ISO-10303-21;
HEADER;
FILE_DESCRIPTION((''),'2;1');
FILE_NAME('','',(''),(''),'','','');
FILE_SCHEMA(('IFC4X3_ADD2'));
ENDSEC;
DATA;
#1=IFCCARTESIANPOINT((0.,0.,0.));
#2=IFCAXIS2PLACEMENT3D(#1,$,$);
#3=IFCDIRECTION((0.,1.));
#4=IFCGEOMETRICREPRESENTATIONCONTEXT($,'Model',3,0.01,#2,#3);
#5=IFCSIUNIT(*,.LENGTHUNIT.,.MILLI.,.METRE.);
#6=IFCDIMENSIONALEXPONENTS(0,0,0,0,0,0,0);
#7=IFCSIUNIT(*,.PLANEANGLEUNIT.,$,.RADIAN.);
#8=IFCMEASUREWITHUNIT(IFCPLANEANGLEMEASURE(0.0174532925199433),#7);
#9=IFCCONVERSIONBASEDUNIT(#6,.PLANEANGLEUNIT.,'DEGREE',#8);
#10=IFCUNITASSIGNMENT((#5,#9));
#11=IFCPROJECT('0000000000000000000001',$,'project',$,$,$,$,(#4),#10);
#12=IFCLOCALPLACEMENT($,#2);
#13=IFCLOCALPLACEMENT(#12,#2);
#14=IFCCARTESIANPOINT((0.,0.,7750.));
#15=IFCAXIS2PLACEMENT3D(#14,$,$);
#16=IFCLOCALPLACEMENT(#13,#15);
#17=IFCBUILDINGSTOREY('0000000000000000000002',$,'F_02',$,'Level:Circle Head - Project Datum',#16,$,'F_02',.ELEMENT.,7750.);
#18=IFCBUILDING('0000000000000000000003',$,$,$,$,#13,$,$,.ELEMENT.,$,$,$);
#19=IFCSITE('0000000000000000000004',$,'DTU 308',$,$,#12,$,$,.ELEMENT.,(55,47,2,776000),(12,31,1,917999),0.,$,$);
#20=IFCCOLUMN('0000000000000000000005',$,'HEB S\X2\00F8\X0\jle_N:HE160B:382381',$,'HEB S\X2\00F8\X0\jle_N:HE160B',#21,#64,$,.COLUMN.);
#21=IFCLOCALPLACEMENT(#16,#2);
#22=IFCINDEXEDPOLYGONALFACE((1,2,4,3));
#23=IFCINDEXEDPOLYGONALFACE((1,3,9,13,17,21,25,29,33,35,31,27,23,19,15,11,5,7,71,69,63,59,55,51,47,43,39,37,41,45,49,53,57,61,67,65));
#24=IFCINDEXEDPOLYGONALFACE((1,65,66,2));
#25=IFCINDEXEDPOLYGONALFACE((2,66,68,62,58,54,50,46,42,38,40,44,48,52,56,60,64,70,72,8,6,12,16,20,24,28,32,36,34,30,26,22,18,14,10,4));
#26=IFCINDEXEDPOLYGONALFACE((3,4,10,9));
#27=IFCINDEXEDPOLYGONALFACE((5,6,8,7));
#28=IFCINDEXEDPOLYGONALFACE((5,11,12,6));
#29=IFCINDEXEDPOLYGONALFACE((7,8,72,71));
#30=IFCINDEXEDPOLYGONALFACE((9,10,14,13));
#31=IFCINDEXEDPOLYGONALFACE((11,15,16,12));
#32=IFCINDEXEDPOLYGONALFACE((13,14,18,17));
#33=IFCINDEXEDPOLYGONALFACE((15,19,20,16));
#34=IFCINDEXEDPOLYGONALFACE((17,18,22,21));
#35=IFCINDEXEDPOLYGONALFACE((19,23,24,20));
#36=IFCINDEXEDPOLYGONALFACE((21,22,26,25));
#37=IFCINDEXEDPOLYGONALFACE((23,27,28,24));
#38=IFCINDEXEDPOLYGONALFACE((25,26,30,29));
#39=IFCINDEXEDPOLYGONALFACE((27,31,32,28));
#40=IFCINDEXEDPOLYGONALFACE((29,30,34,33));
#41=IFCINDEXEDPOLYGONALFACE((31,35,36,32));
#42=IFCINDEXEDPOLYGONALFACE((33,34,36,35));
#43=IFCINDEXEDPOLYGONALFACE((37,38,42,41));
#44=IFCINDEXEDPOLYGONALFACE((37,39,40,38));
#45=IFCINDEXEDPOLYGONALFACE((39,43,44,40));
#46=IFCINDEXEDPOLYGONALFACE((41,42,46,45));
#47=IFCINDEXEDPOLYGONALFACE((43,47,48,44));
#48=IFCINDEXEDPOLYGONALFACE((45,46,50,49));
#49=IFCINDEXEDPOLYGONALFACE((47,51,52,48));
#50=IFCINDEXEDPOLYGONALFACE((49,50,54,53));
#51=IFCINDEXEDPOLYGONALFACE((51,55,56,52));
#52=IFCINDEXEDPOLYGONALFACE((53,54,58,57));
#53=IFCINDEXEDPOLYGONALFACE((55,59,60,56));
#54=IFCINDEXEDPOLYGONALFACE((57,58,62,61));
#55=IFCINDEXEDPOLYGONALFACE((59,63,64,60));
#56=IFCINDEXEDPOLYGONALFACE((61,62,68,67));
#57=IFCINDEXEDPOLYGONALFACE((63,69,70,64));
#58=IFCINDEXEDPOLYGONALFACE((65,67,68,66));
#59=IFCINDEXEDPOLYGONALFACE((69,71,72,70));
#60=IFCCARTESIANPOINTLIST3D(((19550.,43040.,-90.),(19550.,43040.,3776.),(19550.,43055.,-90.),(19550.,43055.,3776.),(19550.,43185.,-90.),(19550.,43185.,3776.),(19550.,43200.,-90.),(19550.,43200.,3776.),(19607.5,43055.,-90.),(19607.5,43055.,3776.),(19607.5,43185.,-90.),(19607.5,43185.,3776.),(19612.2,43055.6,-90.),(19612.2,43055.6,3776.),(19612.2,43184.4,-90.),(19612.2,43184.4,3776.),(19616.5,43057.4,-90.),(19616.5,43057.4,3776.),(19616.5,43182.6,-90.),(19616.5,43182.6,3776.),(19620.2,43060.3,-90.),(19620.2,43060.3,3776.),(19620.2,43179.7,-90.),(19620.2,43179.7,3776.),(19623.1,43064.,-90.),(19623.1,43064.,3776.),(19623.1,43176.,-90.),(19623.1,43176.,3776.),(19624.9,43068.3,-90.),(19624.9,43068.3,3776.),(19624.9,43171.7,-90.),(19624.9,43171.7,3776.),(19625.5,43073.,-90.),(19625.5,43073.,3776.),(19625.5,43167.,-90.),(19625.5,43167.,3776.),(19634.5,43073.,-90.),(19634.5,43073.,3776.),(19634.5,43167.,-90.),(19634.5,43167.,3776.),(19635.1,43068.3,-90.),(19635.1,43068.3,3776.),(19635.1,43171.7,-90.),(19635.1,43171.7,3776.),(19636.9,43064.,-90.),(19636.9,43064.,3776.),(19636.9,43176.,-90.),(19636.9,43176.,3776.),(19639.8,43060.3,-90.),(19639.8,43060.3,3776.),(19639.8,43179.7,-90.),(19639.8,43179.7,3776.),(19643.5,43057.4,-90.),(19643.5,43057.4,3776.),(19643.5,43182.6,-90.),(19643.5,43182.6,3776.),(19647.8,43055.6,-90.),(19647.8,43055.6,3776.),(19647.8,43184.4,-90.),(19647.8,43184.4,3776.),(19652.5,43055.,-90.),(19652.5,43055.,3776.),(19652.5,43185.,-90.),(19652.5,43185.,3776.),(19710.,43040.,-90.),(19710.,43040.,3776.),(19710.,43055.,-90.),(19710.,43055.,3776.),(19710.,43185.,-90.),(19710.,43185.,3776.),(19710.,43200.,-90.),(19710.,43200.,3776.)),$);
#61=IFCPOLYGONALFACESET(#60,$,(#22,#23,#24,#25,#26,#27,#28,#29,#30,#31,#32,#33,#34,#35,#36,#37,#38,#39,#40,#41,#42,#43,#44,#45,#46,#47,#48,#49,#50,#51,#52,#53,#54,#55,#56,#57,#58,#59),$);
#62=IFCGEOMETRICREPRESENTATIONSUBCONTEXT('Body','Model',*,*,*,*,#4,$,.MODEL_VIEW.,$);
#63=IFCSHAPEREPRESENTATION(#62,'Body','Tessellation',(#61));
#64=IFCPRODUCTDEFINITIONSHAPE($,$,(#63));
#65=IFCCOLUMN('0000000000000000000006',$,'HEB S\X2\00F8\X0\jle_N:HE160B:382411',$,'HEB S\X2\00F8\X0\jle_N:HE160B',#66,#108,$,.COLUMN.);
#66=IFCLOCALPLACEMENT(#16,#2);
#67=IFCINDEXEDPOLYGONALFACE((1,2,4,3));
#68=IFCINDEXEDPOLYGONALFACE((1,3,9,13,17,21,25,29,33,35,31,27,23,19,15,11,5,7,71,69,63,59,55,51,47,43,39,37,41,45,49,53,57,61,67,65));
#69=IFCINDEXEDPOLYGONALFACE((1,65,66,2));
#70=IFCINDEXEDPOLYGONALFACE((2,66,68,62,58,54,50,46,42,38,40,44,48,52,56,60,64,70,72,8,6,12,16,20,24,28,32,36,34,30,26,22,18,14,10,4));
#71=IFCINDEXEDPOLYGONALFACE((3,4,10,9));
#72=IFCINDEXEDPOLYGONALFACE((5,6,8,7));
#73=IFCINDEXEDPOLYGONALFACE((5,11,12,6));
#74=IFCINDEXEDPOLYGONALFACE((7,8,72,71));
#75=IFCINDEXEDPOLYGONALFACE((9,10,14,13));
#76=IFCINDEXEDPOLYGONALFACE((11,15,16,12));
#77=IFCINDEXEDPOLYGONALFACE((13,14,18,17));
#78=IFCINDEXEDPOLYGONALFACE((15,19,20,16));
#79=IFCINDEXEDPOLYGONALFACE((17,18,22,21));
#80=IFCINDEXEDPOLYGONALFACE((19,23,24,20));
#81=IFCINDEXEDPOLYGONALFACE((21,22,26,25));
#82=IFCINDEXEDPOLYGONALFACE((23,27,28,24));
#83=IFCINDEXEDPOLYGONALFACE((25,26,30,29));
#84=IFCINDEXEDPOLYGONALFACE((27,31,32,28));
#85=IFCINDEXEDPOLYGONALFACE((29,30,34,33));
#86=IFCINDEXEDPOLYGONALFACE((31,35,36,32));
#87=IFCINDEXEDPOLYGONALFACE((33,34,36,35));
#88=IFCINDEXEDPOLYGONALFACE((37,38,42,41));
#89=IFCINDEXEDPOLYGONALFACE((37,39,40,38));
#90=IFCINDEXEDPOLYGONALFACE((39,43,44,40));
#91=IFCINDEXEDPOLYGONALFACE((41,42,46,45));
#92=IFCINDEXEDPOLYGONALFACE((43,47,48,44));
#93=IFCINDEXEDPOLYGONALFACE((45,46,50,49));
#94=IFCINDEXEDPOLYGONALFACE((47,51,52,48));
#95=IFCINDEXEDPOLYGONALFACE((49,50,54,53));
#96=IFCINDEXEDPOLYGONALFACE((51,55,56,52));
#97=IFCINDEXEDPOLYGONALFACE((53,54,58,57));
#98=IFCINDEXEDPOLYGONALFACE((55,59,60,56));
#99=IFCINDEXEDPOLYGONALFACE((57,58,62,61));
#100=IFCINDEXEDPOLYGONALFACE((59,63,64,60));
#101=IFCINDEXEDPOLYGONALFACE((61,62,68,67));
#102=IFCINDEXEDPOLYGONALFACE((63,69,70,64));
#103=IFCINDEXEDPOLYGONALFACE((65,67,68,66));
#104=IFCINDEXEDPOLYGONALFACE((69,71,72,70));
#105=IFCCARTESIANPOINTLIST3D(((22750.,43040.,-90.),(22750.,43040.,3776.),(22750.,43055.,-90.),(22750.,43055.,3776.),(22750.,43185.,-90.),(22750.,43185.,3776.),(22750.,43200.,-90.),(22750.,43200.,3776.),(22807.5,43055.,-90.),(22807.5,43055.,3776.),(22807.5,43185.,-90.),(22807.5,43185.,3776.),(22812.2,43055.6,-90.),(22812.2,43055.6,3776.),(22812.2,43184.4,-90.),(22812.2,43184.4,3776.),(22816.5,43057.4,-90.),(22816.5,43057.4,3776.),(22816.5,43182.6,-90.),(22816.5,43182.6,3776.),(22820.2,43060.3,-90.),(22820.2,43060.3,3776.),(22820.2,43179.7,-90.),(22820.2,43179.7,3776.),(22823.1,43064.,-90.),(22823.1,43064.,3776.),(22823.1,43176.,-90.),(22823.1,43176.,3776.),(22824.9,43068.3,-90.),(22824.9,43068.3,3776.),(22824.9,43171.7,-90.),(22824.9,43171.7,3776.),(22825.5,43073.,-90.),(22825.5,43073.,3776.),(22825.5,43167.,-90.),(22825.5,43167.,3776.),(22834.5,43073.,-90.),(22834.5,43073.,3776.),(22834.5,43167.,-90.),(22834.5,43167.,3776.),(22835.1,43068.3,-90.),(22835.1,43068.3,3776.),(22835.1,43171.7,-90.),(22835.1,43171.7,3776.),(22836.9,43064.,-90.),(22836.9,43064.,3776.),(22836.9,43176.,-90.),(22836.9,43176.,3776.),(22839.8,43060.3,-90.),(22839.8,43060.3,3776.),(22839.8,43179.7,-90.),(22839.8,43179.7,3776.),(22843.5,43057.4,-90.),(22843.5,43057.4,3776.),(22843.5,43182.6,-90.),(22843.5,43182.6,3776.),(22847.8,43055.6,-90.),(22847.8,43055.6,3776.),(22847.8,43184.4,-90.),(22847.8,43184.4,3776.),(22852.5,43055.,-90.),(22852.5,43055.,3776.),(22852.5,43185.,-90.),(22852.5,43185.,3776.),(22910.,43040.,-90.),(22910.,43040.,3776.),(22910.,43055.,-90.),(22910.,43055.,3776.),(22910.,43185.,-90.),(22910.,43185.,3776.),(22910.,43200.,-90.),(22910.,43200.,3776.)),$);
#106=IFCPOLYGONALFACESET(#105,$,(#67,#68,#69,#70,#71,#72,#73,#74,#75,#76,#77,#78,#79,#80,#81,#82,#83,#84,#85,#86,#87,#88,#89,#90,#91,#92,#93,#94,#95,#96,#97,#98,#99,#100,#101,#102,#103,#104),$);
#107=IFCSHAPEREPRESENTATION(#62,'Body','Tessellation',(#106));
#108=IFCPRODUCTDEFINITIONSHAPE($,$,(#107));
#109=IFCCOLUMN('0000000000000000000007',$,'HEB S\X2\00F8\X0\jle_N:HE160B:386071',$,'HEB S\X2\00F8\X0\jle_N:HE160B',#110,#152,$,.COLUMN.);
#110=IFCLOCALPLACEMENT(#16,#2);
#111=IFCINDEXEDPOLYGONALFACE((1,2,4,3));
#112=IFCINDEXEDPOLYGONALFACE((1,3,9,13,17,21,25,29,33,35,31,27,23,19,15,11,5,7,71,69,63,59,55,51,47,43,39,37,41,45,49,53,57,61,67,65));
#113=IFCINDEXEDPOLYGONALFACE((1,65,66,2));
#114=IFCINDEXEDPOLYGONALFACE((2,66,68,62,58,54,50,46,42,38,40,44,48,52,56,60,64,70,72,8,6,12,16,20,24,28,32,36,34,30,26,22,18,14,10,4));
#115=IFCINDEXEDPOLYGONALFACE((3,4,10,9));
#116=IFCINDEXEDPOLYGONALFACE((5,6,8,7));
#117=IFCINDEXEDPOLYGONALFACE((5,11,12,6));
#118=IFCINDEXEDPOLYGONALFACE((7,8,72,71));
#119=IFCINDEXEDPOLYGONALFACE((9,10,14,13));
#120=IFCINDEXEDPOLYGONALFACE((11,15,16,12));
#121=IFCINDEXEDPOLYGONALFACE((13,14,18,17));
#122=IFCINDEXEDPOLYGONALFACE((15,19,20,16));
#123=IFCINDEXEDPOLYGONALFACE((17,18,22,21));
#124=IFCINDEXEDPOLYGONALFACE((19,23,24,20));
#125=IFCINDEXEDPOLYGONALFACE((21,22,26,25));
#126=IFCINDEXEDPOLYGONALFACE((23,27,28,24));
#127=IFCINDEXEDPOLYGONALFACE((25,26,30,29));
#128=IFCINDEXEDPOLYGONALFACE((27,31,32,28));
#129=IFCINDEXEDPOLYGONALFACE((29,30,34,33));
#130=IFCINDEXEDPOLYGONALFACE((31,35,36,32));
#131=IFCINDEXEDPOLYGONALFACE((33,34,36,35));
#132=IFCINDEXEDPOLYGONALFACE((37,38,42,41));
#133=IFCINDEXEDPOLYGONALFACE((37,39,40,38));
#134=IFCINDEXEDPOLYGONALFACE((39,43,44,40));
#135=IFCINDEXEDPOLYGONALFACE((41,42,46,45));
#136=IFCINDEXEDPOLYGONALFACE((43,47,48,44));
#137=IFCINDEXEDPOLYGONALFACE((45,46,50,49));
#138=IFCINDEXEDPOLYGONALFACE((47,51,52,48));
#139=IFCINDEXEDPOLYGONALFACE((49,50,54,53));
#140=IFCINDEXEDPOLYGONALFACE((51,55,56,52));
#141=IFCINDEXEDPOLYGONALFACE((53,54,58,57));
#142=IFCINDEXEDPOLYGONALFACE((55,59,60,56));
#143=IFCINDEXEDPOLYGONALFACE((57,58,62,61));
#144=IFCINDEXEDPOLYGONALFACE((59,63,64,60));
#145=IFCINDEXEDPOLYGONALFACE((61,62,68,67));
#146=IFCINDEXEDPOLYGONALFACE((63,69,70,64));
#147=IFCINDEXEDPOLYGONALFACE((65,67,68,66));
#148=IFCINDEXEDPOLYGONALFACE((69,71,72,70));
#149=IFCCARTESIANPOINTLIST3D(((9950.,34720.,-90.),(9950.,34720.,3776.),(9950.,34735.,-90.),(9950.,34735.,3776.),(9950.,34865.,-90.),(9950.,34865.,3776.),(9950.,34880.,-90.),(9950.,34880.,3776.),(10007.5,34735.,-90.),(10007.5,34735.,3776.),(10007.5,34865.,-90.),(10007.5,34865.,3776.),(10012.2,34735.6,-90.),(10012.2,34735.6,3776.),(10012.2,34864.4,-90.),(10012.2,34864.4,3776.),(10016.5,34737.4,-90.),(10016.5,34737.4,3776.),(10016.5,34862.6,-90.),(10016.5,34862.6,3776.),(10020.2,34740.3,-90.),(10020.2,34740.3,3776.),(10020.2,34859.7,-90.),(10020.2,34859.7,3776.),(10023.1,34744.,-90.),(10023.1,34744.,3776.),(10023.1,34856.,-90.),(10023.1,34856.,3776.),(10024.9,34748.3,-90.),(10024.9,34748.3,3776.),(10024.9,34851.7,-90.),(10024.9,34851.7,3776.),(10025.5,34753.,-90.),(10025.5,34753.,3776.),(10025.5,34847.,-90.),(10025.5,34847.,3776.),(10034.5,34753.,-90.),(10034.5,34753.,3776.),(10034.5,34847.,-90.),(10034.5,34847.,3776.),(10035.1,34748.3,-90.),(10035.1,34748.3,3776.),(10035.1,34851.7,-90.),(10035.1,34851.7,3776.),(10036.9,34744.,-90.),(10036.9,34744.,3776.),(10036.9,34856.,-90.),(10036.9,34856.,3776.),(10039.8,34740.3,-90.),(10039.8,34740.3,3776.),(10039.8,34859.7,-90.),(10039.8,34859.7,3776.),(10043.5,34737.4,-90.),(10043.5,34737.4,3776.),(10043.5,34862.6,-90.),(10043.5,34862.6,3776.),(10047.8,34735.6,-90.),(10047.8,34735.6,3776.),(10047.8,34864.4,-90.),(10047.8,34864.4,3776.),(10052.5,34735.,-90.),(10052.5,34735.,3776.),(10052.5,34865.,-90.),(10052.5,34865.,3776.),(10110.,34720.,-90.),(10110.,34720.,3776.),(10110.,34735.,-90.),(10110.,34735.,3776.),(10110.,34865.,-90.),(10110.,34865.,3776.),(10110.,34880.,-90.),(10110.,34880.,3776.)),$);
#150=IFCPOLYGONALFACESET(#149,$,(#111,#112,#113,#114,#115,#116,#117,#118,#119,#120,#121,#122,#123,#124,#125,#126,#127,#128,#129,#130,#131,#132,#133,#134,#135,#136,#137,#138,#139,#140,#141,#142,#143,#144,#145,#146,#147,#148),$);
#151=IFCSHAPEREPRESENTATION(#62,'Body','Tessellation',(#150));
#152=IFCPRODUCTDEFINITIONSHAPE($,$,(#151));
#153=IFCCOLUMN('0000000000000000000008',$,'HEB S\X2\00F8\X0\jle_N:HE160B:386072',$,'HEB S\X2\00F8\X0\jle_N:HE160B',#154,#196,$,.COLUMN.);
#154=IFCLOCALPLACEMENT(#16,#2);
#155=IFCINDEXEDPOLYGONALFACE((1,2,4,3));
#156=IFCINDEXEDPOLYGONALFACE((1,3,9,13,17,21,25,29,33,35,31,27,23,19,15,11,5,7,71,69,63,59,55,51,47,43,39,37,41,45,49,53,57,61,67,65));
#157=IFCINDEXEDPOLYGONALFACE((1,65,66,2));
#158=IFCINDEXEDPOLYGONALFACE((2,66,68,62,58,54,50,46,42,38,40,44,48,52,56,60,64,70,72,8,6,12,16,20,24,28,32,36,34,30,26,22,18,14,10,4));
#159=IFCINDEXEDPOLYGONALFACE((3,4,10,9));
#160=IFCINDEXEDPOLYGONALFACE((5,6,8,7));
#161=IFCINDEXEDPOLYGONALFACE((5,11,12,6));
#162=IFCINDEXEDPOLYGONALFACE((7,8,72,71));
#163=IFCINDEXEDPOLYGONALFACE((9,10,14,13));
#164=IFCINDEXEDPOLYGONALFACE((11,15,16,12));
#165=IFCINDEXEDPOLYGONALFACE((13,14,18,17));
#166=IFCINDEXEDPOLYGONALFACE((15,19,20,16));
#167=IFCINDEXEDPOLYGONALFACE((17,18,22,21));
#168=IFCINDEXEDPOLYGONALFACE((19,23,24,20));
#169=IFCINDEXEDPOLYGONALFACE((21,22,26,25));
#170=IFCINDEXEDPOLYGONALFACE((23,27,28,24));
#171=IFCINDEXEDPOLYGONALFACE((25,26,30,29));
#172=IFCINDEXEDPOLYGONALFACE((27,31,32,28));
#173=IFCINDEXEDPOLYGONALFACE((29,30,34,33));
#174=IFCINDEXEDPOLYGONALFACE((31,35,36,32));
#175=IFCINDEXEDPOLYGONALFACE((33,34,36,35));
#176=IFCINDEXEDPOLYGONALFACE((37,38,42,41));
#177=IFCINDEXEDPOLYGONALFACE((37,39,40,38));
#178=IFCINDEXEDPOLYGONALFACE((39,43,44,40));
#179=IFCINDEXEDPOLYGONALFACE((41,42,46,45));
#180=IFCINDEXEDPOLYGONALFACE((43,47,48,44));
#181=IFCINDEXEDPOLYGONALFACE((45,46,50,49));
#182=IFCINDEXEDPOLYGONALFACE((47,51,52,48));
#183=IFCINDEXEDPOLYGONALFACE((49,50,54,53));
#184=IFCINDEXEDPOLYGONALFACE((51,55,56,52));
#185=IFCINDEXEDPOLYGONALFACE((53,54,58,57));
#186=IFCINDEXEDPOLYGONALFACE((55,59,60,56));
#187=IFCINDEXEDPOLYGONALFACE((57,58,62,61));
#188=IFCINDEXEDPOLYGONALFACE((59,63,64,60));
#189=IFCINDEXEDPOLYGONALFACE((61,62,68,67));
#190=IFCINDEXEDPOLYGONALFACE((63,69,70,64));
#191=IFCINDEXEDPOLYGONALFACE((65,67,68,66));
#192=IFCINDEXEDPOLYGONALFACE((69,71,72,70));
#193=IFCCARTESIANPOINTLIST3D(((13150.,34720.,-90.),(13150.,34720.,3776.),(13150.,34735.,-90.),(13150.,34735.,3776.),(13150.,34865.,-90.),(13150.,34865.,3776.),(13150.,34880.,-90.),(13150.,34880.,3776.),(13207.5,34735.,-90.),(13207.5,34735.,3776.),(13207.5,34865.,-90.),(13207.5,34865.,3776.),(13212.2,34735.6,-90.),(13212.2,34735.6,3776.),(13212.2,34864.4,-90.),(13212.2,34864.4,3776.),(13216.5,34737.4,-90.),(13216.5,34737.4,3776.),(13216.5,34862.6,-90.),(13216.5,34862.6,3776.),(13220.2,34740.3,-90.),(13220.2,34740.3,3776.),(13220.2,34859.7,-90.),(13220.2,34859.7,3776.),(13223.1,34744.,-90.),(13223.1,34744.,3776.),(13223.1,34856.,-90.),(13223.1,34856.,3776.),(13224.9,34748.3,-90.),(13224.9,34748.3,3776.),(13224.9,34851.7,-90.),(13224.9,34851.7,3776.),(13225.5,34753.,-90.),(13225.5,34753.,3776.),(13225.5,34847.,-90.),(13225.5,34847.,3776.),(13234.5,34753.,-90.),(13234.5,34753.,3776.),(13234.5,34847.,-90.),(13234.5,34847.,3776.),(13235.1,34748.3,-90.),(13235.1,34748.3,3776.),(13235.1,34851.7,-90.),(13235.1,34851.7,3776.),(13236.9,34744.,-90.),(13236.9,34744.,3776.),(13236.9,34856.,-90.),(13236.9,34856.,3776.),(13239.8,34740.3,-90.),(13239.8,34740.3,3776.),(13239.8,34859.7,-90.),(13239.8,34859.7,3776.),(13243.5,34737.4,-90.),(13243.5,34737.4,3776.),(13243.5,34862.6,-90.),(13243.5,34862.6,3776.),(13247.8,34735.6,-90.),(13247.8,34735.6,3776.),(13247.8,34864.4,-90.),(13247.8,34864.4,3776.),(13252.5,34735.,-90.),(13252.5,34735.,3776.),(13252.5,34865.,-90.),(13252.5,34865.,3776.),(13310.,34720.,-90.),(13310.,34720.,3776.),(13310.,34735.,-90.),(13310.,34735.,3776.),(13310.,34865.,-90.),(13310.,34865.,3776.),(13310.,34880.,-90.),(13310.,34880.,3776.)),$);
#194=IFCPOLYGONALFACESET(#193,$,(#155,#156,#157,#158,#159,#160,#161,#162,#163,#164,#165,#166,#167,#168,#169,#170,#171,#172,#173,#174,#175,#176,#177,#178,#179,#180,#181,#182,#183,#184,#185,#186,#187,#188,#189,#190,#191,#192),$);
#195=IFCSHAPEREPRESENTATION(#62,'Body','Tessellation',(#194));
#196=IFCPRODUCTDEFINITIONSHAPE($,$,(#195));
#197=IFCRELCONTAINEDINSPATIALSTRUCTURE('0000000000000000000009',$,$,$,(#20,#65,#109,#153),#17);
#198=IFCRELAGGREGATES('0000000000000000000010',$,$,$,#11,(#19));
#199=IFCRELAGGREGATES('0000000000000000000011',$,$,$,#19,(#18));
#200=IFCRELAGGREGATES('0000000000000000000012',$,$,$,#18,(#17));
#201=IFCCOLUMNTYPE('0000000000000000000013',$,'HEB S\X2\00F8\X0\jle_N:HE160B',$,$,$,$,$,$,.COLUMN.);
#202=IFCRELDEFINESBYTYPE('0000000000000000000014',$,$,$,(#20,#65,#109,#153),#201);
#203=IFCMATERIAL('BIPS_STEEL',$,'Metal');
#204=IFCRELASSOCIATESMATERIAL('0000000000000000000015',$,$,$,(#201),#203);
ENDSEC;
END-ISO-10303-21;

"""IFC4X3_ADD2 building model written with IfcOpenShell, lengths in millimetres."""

from ifc_helpers import new_model, entity, si_unit, converted_unit, direction, frame, frame_2d, origin, place, context, subcontext, project, spatial, i_section, extrude, source, transform, mapped, material, material_profile, profile_set, type_object, element, save


model = new_model("IFC4X3_ADD2")

# Units and contexts
model_context = context("Model", 3, precision=0.01, world=origin(), true_north=direction((0.0, 1.0)))
body_context = subcontext(model_context, "Body", "Model", "MODEL_VIEW")
ifc_project = project(units=[si_unit("LENGTHUNIT", "METRE", prefix="MILLI"), converted_unit("PLANEANGLEUNIT", "DEGREE", entity("IfcPlaneAngleMeasure", 0.0174532925199433), si_unit("PLANEANGLEUNIT", "RADIAN"), dimensions=[0, 0, 0, 0, 0, 0, 0])], contexts=[model_context])

# Site, building, storey
site_placement = place(None, origin())
site = spatial("IfcSite", under=ifc_project, at=site_placement, Name="DTU 308", CompositionType="ELEMENT", RefLatitude=(55, 47, 2, 776000), RefLongitude=(12, 31, 1, 917999), RefElevation=0.0)
building_placement = place(site_placement, origin())
building = spatial("IfcBuilding", under=site, at=building_placement, CompositionType="ELEMENT")
storey_placement = place(building_placement, frame((0.0, 0.0, 7750.0)))
storey = spatial("IfcBuildingStorey", under=building, at=storey_placement, Name="F_02", ObjectType="Level:Circle Head - Project Datum", LongName="F_02", CompositionType="ELEMENT", Elevation=7750.0)

# Columns
ifc_material = material(Name="BIPS_STEEL", Category="Metal")
ifc_material_profile_1 = material_profile(ifc_material, i_section(OverallWidth=160.0, OverallDepth=160.0, WebThickness=9.0, FlangeThickness=15.0, FilletRadius=18.0, at=frame_2d((0.0, 0.0), x_axis=(1.0, 0.0))), Name="HE160B")
ifc_profile_set_1 = profile_set([ifc_material_profile_1], Name="HE160B")
column_type_1 = type_object("IfcColumnType", Name="HEB Søjle_N:HE160B", PredefinedType="COLUMN", material=ifc_profile_set_1)
shared_shape_1 = source(origin(), body_context, "Body", "SweptSolid", [
    extrude(i_section(OverallWidth=160.0, OverallDepth=160.0, WebThickness=9.0, FlangeThickness=15.0, FilletRadius=18.0, at=frame_2d((0.0, 0.0), x_axis=(1.0, 0.0))), frame((0.0, 0.0, 7660.0), z_axis=(0.0, 0.0, 1.0), x_axis=(-1.0, 0.0, 0.0)), (0.0, 0.0, 1.0), 3866.0),
])
for number, where, name in (
    (1, (19630.0, 43120.0, -7750.0), "HEB Søjle_N:HE160B:382381"),
    (2, (22830.0, 43120.0, -7750.0), "HEB Søjle_N:HE160B:382411"),
    (3, (10030.0, 34800.0, -7750.0), "HEB Søjle_N:HE160B:386071"),
    (4, (13230.0, 34800.0, -7750.0), "HEB Søjle_N:HE160B:386072"),
):
    element("IfcColumn", number, at=place(storey_placement, frame(where)), inside=storey, type_object=column_type_1, Name=name, ObjectType="HEB Søjle_N:HE160B", PredefinedType="COLUMN", context=body_context, shape_type="MappedRepresentation", body=[
        mapped(shared_shape_1, transform((0.0, 0.0, 0.0), scale=1.0)),
    ])

save(model, "model.ifc")
